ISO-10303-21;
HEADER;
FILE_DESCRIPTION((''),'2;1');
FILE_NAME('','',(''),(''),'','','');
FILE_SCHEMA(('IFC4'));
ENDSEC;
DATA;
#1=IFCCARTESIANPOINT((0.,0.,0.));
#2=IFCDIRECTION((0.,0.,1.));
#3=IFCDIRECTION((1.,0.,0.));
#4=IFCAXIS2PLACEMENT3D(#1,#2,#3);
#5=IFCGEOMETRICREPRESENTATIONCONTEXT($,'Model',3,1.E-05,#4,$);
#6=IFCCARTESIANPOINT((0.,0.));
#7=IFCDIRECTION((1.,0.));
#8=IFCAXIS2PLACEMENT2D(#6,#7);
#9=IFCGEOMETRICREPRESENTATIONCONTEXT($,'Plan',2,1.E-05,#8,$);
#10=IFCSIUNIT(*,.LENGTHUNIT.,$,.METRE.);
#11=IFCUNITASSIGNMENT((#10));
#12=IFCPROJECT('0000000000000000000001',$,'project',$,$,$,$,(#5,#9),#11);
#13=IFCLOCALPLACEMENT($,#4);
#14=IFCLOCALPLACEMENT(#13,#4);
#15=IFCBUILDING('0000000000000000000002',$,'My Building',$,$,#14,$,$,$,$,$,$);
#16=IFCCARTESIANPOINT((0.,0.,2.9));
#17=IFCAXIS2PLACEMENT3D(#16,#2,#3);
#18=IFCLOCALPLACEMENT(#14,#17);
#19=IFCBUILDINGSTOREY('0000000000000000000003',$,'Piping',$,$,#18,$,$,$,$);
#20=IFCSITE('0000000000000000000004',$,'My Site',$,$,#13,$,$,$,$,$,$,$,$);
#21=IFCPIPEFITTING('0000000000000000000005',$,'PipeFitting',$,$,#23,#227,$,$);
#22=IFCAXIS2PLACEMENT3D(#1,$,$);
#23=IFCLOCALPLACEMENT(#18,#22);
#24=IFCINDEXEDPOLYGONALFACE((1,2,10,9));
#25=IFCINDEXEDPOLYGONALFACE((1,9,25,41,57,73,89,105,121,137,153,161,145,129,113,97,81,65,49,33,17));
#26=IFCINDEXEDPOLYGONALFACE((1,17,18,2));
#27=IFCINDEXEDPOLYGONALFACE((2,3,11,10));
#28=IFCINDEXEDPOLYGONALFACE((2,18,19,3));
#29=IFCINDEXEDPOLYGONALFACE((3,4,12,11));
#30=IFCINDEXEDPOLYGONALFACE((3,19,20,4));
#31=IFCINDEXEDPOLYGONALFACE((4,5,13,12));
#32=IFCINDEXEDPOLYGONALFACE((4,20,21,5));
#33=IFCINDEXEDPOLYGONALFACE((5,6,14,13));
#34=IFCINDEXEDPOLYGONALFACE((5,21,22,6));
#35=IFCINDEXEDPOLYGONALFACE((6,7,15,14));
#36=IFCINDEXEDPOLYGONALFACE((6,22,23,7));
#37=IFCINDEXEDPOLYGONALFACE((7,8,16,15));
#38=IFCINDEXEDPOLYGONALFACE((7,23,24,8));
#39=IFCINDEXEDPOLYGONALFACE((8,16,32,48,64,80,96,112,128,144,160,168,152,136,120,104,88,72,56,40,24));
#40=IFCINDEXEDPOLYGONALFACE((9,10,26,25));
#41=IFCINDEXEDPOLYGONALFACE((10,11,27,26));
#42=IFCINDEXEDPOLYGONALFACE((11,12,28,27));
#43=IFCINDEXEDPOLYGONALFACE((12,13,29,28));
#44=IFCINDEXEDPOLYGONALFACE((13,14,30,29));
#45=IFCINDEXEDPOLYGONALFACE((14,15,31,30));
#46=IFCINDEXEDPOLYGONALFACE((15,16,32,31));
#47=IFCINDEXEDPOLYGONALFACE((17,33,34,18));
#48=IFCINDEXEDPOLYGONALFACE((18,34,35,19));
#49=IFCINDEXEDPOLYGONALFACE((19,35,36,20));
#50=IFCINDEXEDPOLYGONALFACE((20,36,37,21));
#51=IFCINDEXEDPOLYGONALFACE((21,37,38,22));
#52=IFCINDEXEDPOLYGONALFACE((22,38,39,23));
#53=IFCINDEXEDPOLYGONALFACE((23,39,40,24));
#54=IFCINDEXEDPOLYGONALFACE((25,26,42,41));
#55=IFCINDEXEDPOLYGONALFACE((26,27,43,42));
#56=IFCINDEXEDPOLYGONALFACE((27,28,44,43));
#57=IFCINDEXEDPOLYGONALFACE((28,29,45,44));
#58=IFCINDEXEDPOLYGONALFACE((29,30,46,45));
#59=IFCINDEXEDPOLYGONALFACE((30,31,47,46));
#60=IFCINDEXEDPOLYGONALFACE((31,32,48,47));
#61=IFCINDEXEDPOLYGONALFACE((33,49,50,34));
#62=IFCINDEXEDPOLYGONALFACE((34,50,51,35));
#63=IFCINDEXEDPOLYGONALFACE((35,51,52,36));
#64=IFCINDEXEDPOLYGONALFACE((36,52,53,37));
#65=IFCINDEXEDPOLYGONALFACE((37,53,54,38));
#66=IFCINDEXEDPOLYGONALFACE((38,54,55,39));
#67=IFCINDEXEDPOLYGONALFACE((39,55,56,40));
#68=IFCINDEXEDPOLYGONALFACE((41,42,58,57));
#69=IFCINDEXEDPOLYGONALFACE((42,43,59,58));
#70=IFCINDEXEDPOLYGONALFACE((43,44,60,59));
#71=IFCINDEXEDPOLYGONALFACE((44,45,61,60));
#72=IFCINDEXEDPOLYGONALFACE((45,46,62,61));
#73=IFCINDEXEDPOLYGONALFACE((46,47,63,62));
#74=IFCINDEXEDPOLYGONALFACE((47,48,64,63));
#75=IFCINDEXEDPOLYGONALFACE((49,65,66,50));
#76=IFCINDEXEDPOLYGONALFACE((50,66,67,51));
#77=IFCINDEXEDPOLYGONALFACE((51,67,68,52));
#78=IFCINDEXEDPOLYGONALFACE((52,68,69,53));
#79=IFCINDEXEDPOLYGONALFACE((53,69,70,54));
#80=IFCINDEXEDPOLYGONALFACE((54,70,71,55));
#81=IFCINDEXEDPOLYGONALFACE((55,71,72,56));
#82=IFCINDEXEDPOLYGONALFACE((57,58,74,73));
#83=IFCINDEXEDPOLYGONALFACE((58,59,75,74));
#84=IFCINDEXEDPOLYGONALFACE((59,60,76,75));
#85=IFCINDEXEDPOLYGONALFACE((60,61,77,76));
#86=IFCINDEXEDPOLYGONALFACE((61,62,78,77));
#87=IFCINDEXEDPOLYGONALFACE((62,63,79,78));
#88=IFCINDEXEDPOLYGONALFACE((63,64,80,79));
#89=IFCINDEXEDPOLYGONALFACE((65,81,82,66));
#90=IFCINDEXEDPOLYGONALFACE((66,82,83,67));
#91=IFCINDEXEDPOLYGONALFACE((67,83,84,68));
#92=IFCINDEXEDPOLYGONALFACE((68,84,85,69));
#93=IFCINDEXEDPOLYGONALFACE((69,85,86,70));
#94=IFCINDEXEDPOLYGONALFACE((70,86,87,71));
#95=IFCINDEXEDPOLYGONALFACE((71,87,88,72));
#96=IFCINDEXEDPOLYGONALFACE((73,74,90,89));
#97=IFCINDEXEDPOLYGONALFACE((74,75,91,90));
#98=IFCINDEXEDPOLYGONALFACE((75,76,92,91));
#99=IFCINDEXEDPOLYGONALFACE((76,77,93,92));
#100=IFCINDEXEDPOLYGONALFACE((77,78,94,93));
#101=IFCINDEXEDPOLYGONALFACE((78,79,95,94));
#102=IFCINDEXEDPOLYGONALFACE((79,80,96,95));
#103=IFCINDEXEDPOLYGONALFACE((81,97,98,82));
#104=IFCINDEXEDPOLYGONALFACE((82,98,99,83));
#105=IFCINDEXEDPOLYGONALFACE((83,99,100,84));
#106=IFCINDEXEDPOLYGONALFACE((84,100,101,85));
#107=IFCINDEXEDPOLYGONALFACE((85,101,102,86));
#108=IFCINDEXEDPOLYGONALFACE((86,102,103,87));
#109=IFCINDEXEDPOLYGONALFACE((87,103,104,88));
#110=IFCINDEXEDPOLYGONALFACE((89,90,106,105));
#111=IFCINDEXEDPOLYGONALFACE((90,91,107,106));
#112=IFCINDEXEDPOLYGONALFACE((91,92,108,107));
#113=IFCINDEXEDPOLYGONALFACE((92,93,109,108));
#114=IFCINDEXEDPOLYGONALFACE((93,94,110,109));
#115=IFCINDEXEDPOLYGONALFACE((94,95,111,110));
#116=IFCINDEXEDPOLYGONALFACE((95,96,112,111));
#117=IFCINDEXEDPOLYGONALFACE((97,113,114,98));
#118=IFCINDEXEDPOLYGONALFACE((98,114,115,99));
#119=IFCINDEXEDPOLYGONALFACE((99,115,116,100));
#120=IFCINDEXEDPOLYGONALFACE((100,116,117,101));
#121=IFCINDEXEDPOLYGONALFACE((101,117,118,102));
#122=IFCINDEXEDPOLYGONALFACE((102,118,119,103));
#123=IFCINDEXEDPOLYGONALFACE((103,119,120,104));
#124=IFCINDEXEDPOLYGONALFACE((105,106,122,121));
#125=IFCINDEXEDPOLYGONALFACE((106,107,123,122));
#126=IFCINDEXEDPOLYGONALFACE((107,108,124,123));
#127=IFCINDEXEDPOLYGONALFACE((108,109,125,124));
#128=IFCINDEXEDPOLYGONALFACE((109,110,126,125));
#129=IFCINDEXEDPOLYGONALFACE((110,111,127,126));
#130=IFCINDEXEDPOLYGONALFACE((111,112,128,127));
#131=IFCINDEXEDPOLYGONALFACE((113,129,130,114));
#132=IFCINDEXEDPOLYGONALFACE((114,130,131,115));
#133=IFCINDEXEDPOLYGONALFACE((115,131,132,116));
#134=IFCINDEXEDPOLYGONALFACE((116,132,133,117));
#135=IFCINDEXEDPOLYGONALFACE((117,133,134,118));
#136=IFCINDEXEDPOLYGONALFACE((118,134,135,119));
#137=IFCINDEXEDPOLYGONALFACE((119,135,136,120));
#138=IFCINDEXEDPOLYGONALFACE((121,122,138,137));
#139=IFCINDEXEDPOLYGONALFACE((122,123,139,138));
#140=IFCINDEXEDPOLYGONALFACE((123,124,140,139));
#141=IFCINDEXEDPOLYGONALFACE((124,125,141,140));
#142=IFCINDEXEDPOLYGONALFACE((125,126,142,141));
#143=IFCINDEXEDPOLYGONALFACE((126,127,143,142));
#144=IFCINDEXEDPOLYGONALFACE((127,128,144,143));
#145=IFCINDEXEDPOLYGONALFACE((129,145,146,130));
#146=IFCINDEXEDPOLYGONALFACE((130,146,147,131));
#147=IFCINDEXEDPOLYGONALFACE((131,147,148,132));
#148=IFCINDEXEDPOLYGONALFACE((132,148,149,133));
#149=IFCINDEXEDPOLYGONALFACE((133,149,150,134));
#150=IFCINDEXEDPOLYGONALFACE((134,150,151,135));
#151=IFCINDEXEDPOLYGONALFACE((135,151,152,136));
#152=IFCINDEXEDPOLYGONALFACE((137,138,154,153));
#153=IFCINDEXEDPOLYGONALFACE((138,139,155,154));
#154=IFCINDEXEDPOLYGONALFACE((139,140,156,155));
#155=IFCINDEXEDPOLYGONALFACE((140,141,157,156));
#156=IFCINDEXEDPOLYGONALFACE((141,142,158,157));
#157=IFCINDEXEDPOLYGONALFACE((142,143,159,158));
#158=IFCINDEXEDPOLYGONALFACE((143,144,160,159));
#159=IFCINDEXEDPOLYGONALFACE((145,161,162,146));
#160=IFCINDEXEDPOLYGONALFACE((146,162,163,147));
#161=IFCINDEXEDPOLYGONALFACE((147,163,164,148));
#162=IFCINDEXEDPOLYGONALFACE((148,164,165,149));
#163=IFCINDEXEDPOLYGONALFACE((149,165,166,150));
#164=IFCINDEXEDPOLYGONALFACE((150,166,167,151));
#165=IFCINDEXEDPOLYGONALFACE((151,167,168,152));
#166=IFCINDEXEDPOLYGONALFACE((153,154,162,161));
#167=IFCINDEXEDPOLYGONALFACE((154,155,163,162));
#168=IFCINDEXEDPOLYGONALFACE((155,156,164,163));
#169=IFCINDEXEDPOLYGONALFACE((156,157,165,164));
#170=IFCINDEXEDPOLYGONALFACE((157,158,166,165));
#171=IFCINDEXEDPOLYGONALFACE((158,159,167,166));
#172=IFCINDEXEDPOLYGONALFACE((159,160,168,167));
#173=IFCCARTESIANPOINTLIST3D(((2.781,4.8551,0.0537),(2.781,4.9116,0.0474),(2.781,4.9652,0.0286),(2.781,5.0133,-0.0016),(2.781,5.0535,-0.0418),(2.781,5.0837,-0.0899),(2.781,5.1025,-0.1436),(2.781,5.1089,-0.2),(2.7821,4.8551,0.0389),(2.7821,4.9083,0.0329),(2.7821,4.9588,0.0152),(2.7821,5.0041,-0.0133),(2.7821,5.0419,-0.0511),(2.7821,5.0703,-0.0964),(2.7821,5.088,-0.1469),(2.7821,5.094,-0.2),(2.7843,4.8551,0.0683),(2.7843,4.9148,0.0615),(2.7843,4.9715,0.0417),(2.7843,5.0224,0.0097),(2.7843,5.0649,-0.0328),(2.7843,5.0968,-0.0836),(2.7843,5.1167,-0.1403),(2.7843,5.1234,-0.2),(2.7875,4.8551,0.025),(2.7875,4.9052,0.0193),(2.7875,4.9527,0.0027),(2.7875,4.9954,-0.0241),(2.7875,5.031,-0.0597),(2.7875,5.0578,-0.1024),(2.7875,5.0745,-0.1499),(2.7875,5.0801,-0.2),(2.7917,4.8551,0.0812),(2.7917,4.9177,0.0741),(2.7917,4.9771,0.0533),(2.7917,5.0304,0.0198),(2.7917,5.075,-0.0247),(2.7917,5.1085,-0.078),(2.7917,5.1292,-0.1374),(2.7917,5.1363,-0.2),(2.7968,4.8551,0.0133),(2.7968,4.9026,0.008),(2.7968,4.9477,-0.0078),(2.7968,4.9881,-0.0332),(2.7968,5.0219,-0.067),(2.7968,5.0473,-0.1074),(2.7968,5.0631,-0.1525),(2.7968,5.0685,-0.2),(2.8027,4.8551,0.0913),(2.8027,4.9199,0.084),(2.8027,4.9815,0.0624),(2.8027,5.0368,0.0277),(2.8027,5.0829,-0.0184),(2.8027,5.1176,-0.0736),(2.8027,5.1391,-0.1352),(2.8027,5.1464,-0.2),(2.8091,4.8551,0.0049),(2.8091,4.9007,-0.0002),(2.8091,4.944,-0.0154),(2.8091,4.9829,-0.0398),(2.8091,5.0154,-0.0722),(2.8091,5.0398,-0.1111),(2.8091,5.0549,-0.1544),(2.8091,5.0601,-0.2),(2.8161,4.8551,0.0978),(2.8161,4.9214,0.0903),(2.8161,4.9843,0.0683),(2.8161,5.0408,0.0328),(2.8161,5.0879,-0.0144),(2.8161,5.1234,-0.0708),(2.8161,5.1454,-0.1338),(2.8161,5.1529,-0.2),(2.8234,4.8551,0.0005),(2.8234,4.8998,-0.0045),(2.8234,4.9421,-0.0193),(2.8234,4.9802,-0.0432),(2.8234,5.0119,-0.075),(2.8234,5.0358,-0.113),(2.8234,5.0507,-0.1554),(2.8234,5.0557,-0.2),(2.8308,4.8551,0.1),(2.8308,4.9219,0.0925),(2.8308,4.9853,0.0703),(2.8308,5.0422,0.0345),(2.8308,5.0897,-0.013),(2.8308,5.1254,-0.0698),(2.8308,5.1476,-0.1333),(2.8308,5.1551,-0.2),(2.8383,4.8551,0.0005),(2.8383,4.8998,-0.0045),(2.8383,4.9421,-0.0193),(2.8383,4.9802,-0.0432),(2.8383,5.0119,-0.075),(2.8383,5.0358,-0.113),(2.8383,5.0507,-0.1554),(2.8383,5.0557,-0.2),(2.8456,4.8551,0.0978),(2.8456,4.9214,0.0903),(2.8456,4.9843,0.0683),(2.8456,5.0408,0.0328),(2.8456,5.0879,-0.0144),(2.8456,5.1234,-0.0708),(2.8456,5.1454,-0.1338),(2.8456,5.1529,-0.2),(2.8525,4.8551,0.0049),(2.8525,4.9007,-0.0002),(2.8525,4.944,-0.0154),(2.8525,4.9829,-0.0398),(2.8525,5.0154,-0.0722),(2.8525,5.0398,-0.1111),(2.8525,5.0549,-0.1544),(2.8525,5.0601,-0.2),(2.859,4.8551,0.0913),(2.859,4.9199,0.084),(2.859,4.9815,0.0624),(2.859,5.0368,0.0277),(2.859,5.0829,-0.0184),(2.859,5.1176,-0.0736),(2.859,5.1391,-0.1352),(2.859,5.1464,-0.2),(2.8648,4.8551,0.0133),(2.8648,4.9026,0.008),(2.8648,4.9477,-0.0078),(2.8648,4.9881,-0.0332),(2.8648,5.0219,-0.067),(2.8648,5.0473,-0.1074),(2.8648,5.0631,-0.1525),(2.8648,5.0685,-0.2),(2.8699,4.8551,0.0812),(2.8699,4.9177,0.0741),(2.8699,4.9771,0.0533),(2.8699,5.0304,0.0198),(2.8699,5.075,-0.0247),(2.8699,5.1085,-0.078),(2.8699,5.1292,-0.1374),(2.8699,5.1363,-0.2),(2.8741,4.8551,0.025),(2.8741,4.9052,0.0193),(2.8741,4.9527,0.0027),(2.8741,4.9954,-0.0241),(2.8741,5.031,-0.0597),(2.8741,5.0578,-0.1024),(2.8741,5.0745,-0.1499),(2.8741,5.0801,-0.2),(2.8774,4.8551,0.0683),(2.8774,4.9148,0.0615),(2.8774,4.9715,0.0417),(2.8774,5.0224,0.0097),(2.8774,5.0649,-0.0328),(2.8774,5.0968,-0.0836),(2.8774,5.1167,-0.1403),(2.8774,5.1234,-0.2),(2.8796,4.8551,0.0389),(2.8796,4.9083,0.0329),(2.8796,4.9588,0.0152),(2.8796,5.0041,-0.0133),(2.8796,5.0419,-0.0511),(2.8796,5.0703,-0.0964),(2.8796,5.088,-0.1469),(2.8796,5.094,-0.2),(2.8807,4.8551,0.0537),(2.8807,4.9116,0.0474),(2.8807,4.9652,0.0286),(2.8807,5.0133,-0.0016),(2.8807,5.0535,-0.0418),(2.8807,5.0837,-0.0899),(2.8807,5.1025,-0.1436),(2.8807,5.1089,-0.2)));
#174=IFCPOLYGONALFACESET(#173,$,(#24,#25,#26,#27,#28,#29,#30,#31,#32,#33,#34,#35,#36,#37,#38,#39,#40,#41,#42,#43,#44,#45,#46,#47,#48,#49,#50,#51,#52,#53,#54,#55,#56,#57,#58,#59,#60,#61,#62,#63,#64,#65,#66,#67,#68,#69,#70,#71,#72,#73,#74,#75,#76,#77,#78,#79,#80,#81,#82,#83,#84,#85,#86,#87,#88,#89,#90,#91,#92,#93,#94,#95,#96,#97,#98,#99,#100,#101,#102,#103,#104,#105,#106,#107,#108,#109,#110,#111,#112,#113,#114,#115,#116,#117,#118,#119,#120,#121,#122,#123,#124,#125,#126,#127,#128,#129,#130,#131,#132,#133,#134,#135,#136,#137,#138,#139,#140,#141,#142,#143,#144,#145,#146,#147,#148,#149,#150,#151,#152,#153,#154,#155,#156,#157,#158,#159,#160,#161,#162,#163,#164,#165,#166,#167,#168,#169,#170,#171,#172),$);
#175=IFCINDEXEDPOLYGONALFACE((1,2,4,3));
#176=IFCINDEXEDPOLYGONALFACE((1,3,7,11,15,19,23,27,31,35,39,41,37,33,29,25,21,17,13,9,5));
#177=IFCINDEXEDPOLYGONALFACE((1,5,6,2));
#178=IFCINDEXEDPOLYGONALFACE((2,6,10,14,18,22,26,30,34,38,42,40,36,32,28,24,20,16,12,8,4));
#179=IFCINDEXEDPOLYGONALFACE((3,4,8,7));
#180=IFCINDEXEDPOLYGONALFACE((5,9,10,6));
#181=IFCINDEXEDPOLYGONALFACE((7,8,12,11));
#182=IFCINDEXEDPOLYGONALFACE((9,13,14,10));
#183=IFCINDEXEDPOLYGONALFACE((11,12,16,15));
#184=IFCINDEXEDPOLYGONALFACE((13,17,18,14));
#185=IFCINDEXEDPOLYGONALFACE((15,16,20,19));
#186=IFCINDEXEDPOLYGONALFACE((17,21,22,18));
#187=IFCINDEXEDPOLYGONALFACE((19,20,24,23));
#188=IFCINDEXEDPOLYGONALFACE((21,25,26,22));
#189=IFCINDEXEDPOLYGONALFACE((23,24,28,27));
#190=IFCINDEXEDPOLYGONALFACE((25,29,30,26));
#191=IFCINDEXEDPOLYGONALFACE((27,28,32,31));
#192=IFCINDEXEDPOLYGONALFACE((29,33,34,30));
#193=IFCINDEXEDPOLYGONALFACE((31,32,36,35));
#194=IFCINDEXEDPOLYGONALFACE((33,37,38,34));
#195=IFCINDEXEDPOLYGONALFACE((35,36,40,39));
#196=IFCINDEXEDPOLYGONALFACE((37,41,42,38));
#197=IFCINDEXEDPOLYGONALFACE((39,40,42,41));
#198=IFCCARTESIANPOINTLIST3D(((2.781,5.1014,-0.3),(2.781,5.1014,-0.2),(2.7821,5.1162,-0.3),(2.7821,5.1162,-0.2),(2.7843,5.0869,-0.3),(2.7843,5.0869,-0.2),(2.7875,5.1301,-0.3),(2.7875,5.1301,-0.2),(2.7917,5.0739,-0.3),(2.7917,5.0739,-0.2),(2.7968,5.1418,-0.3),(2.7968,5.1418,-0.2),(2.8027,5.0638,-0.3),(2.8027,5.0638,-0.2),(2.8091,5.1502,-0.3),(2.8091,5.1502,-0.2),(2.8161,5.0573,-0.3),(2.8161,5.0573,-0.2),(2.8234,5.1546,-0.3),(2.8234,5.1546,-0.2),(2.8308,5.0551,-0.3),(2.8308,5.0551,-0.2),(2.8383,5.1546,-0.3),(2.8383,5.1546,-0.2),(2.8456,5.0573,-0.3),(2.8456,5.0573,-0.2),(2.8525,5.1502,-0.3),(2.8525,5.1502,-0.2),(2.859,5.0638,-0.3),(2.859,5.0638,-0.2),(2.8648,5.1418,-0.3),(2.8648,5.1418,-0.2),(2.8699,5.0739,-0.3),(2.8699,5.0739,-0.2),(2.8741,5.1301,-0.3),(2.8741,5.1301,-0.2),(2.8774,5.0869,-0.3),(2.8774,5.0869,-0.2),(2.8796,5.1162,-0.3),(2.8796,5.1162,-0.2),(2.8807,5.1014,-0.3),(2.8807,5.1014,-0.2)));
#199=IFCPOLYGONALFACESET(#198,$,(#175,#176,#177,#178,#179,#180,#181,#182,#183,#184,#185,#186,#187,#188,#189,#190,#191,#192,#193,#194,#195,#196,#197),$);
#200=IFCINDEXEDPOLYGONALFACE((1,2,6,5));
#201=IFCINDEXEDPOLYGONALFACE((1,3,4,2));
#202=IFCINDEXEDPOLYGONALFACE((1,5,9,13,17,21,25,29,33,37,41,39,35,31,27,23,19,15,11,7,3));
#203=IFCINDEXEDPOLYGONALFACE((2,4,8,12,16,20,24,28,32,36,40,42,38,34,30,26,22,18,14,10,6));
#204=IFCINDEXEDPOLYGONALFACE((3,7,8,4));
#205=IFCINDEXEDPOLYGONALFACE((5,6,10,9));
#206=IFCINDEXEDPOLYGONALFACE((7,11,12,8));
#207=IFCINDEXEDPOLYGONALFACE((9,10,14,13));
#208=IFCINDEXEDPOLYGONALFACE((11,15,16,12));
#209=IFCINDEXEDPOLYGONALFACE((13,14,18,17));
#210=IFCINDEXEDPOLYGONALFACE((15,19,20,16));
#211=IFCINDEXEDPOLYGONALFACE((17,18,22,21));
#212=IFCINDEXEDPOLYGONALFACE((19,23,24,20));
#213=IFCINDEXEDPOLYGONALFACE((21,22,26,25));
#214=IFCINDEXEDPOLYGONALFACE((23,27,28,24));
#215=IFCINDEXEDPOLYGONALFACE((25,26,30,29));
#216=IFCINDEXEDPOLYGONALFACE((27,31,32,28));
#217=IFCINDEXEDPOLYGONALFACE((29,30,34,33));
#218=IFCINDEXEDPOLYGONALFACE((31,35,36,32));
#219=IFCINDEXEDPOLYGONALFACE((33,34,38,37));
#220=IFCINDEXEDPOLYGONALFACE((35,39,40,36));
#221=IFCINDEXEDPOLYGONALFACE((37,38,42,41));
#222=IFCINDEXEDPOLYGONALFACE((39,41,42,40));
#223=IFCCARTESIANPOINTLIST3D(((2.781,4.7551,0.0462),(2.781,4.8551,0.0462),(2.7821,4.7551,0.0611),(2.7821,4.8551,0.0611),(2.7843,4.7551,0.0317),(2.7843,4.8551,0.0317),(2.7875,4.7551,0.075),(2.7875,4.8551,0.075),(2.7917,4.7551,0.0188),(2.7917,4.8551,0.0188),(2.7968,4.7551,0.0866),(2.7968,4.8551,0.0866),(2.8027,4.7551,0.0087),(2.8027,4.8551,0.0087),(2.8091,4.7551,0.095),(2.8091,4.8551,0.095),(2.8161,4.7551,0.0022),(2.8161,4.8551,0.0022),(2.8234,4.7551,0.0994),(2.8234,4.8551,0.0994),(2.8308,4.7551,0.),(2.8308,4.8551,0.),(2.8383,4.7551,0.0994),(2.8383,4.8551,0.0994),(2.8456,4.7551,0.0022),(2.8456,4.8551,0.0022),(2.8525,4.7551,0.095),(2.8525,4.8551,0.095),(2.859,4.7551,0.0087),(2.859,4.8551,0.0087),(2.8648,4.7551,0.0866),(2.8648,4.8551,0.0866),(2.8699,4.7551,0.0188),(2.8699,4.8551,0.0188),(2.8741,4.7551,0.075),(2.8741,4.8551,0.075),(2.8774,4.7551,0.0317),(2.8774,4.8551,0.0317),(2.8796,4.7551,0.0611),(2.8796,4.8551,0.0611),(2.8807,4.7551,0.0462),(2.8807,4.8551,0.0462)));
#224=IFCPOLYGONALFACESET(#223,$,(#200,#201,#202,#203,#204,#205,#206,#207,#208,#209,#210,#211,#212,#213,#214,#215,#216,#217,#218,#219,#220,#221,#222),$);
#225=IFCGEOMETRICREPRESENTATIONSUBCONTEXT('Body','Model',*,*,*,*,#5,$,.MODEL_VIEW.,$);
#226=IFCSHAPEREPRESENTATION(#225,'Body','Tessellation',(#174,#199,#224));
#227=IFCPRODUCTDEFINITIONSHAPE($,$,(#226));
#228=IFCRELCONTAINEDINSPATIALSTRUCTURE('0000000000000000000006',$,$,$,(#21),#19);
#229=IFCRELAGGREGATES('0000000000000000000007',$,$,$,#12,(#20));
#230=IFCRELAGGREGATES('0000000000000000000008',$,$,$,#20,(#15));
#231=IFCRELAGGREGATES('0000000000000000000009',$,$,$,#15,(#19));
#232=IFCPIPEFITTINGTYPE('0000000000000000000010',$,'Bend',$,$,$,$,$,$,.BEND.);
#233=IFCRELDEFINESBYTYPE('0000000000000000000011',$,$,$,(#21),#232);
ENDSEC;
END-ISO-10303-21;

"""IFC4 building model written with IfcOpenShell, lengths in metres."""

from ifc_helpers import new_model, entity, si_unit, frame, origin_with_axes, origin_2d_with_axis, place, context, subcontext, project, spatial, circle, extrude, source, transform, mapped, type_object, type_shapes, element, save


model = new_model("IFC4")

# Units and contexts
model_context = context("Model", 3, precision=1e-05, world=origin_with_axes())
plan_context = context("Plan", 2, precision=1e-05, world=origin_2d_with_axis())
body_context = subcontext(model_context, "Body", "Model", "MODEL_VIEW")
ifc_project = project(units=[si_unit("LENGTHUNIT", "METRE")], contexts=[model_context, plan_context])

# Site, building, storey
site_placement = place(None, origin_with_axes())
site = spatial("IfcSite", under=ifc_project, at=site_placement, Name="My Site")
building_placement = place(site_placement, origin_with_axes())
building = spatial("IfcBuilding", under=site, at=building_placement, Name="My Building")
storey_placement = place(building_placement, frame((0.0, 0.0, 2.9), z_axis=(0.0, 0.0, 1.0), x_axis=(1.0, 0.0, 0.0)))
storey = spatial("IfcBuildingStorey", under=building, at=storey_placement, Name="Piping")

# Pipe fitting
pipe_fitting_type_1 = type_object("IfcPipeFittingType", Name="Bend", PredefinedType="BEND")
shared_shape = source(origin_with_axes(), body_context, "Body", "SolidModel", [
    entity("IfcSweptDiskSolid", entity("IfcIndexedPolyCurve", entity("IfcCartesianPointList3D", [[0.0, 0.0, -0.1], [0.0732, 0.0, -0.2768], [0.25, 0.0, -0.35]]), [entity("IfcArcIndex", [1, 2, 3])]), 0.05),
    extrude(circle(Radius=0.05), origin_with_axes(), (0.0, 0.0, -1.0), 0.1),
    extrude(circle(Radius=0.05), frame((0.25, 0.0, -0.35), z_axis=(1.0, 0.0, 0.0), x_axis=(0.0, 0.0, 1.0)), (0.0, 0.0, 1.0), 0.1),
])
type_shapes(pipe_fitting_type_1, [shared_shape])
for number, where, z_axis, x_axis, name in (
    (1, (2.8308, 5.1051, -0.3), (0.0, 0.0, -1.0), (0.0, -1.0, 0.0), "PipeFitting"),
):
    element("IfcPipeFitting", number, at=place(storey_placement, frame(where, z_axis=z_axis, x_axis=x_axis)), inside=storey, type_object=pipe_fitting_type_1, Name=name, context=body_context, shape_type="MappedRepresentation", body=[
        mapped(shared_shape, transform((0.0, 0.0, 0.0), x_axis=(1.0, 0.0, 0.0), y_axis=(0.0, 1.0, 0.0), z_axis=(0.0, 0.0, 1.0), scale=1.0)),
    ])

save(model, "model.ifc")
